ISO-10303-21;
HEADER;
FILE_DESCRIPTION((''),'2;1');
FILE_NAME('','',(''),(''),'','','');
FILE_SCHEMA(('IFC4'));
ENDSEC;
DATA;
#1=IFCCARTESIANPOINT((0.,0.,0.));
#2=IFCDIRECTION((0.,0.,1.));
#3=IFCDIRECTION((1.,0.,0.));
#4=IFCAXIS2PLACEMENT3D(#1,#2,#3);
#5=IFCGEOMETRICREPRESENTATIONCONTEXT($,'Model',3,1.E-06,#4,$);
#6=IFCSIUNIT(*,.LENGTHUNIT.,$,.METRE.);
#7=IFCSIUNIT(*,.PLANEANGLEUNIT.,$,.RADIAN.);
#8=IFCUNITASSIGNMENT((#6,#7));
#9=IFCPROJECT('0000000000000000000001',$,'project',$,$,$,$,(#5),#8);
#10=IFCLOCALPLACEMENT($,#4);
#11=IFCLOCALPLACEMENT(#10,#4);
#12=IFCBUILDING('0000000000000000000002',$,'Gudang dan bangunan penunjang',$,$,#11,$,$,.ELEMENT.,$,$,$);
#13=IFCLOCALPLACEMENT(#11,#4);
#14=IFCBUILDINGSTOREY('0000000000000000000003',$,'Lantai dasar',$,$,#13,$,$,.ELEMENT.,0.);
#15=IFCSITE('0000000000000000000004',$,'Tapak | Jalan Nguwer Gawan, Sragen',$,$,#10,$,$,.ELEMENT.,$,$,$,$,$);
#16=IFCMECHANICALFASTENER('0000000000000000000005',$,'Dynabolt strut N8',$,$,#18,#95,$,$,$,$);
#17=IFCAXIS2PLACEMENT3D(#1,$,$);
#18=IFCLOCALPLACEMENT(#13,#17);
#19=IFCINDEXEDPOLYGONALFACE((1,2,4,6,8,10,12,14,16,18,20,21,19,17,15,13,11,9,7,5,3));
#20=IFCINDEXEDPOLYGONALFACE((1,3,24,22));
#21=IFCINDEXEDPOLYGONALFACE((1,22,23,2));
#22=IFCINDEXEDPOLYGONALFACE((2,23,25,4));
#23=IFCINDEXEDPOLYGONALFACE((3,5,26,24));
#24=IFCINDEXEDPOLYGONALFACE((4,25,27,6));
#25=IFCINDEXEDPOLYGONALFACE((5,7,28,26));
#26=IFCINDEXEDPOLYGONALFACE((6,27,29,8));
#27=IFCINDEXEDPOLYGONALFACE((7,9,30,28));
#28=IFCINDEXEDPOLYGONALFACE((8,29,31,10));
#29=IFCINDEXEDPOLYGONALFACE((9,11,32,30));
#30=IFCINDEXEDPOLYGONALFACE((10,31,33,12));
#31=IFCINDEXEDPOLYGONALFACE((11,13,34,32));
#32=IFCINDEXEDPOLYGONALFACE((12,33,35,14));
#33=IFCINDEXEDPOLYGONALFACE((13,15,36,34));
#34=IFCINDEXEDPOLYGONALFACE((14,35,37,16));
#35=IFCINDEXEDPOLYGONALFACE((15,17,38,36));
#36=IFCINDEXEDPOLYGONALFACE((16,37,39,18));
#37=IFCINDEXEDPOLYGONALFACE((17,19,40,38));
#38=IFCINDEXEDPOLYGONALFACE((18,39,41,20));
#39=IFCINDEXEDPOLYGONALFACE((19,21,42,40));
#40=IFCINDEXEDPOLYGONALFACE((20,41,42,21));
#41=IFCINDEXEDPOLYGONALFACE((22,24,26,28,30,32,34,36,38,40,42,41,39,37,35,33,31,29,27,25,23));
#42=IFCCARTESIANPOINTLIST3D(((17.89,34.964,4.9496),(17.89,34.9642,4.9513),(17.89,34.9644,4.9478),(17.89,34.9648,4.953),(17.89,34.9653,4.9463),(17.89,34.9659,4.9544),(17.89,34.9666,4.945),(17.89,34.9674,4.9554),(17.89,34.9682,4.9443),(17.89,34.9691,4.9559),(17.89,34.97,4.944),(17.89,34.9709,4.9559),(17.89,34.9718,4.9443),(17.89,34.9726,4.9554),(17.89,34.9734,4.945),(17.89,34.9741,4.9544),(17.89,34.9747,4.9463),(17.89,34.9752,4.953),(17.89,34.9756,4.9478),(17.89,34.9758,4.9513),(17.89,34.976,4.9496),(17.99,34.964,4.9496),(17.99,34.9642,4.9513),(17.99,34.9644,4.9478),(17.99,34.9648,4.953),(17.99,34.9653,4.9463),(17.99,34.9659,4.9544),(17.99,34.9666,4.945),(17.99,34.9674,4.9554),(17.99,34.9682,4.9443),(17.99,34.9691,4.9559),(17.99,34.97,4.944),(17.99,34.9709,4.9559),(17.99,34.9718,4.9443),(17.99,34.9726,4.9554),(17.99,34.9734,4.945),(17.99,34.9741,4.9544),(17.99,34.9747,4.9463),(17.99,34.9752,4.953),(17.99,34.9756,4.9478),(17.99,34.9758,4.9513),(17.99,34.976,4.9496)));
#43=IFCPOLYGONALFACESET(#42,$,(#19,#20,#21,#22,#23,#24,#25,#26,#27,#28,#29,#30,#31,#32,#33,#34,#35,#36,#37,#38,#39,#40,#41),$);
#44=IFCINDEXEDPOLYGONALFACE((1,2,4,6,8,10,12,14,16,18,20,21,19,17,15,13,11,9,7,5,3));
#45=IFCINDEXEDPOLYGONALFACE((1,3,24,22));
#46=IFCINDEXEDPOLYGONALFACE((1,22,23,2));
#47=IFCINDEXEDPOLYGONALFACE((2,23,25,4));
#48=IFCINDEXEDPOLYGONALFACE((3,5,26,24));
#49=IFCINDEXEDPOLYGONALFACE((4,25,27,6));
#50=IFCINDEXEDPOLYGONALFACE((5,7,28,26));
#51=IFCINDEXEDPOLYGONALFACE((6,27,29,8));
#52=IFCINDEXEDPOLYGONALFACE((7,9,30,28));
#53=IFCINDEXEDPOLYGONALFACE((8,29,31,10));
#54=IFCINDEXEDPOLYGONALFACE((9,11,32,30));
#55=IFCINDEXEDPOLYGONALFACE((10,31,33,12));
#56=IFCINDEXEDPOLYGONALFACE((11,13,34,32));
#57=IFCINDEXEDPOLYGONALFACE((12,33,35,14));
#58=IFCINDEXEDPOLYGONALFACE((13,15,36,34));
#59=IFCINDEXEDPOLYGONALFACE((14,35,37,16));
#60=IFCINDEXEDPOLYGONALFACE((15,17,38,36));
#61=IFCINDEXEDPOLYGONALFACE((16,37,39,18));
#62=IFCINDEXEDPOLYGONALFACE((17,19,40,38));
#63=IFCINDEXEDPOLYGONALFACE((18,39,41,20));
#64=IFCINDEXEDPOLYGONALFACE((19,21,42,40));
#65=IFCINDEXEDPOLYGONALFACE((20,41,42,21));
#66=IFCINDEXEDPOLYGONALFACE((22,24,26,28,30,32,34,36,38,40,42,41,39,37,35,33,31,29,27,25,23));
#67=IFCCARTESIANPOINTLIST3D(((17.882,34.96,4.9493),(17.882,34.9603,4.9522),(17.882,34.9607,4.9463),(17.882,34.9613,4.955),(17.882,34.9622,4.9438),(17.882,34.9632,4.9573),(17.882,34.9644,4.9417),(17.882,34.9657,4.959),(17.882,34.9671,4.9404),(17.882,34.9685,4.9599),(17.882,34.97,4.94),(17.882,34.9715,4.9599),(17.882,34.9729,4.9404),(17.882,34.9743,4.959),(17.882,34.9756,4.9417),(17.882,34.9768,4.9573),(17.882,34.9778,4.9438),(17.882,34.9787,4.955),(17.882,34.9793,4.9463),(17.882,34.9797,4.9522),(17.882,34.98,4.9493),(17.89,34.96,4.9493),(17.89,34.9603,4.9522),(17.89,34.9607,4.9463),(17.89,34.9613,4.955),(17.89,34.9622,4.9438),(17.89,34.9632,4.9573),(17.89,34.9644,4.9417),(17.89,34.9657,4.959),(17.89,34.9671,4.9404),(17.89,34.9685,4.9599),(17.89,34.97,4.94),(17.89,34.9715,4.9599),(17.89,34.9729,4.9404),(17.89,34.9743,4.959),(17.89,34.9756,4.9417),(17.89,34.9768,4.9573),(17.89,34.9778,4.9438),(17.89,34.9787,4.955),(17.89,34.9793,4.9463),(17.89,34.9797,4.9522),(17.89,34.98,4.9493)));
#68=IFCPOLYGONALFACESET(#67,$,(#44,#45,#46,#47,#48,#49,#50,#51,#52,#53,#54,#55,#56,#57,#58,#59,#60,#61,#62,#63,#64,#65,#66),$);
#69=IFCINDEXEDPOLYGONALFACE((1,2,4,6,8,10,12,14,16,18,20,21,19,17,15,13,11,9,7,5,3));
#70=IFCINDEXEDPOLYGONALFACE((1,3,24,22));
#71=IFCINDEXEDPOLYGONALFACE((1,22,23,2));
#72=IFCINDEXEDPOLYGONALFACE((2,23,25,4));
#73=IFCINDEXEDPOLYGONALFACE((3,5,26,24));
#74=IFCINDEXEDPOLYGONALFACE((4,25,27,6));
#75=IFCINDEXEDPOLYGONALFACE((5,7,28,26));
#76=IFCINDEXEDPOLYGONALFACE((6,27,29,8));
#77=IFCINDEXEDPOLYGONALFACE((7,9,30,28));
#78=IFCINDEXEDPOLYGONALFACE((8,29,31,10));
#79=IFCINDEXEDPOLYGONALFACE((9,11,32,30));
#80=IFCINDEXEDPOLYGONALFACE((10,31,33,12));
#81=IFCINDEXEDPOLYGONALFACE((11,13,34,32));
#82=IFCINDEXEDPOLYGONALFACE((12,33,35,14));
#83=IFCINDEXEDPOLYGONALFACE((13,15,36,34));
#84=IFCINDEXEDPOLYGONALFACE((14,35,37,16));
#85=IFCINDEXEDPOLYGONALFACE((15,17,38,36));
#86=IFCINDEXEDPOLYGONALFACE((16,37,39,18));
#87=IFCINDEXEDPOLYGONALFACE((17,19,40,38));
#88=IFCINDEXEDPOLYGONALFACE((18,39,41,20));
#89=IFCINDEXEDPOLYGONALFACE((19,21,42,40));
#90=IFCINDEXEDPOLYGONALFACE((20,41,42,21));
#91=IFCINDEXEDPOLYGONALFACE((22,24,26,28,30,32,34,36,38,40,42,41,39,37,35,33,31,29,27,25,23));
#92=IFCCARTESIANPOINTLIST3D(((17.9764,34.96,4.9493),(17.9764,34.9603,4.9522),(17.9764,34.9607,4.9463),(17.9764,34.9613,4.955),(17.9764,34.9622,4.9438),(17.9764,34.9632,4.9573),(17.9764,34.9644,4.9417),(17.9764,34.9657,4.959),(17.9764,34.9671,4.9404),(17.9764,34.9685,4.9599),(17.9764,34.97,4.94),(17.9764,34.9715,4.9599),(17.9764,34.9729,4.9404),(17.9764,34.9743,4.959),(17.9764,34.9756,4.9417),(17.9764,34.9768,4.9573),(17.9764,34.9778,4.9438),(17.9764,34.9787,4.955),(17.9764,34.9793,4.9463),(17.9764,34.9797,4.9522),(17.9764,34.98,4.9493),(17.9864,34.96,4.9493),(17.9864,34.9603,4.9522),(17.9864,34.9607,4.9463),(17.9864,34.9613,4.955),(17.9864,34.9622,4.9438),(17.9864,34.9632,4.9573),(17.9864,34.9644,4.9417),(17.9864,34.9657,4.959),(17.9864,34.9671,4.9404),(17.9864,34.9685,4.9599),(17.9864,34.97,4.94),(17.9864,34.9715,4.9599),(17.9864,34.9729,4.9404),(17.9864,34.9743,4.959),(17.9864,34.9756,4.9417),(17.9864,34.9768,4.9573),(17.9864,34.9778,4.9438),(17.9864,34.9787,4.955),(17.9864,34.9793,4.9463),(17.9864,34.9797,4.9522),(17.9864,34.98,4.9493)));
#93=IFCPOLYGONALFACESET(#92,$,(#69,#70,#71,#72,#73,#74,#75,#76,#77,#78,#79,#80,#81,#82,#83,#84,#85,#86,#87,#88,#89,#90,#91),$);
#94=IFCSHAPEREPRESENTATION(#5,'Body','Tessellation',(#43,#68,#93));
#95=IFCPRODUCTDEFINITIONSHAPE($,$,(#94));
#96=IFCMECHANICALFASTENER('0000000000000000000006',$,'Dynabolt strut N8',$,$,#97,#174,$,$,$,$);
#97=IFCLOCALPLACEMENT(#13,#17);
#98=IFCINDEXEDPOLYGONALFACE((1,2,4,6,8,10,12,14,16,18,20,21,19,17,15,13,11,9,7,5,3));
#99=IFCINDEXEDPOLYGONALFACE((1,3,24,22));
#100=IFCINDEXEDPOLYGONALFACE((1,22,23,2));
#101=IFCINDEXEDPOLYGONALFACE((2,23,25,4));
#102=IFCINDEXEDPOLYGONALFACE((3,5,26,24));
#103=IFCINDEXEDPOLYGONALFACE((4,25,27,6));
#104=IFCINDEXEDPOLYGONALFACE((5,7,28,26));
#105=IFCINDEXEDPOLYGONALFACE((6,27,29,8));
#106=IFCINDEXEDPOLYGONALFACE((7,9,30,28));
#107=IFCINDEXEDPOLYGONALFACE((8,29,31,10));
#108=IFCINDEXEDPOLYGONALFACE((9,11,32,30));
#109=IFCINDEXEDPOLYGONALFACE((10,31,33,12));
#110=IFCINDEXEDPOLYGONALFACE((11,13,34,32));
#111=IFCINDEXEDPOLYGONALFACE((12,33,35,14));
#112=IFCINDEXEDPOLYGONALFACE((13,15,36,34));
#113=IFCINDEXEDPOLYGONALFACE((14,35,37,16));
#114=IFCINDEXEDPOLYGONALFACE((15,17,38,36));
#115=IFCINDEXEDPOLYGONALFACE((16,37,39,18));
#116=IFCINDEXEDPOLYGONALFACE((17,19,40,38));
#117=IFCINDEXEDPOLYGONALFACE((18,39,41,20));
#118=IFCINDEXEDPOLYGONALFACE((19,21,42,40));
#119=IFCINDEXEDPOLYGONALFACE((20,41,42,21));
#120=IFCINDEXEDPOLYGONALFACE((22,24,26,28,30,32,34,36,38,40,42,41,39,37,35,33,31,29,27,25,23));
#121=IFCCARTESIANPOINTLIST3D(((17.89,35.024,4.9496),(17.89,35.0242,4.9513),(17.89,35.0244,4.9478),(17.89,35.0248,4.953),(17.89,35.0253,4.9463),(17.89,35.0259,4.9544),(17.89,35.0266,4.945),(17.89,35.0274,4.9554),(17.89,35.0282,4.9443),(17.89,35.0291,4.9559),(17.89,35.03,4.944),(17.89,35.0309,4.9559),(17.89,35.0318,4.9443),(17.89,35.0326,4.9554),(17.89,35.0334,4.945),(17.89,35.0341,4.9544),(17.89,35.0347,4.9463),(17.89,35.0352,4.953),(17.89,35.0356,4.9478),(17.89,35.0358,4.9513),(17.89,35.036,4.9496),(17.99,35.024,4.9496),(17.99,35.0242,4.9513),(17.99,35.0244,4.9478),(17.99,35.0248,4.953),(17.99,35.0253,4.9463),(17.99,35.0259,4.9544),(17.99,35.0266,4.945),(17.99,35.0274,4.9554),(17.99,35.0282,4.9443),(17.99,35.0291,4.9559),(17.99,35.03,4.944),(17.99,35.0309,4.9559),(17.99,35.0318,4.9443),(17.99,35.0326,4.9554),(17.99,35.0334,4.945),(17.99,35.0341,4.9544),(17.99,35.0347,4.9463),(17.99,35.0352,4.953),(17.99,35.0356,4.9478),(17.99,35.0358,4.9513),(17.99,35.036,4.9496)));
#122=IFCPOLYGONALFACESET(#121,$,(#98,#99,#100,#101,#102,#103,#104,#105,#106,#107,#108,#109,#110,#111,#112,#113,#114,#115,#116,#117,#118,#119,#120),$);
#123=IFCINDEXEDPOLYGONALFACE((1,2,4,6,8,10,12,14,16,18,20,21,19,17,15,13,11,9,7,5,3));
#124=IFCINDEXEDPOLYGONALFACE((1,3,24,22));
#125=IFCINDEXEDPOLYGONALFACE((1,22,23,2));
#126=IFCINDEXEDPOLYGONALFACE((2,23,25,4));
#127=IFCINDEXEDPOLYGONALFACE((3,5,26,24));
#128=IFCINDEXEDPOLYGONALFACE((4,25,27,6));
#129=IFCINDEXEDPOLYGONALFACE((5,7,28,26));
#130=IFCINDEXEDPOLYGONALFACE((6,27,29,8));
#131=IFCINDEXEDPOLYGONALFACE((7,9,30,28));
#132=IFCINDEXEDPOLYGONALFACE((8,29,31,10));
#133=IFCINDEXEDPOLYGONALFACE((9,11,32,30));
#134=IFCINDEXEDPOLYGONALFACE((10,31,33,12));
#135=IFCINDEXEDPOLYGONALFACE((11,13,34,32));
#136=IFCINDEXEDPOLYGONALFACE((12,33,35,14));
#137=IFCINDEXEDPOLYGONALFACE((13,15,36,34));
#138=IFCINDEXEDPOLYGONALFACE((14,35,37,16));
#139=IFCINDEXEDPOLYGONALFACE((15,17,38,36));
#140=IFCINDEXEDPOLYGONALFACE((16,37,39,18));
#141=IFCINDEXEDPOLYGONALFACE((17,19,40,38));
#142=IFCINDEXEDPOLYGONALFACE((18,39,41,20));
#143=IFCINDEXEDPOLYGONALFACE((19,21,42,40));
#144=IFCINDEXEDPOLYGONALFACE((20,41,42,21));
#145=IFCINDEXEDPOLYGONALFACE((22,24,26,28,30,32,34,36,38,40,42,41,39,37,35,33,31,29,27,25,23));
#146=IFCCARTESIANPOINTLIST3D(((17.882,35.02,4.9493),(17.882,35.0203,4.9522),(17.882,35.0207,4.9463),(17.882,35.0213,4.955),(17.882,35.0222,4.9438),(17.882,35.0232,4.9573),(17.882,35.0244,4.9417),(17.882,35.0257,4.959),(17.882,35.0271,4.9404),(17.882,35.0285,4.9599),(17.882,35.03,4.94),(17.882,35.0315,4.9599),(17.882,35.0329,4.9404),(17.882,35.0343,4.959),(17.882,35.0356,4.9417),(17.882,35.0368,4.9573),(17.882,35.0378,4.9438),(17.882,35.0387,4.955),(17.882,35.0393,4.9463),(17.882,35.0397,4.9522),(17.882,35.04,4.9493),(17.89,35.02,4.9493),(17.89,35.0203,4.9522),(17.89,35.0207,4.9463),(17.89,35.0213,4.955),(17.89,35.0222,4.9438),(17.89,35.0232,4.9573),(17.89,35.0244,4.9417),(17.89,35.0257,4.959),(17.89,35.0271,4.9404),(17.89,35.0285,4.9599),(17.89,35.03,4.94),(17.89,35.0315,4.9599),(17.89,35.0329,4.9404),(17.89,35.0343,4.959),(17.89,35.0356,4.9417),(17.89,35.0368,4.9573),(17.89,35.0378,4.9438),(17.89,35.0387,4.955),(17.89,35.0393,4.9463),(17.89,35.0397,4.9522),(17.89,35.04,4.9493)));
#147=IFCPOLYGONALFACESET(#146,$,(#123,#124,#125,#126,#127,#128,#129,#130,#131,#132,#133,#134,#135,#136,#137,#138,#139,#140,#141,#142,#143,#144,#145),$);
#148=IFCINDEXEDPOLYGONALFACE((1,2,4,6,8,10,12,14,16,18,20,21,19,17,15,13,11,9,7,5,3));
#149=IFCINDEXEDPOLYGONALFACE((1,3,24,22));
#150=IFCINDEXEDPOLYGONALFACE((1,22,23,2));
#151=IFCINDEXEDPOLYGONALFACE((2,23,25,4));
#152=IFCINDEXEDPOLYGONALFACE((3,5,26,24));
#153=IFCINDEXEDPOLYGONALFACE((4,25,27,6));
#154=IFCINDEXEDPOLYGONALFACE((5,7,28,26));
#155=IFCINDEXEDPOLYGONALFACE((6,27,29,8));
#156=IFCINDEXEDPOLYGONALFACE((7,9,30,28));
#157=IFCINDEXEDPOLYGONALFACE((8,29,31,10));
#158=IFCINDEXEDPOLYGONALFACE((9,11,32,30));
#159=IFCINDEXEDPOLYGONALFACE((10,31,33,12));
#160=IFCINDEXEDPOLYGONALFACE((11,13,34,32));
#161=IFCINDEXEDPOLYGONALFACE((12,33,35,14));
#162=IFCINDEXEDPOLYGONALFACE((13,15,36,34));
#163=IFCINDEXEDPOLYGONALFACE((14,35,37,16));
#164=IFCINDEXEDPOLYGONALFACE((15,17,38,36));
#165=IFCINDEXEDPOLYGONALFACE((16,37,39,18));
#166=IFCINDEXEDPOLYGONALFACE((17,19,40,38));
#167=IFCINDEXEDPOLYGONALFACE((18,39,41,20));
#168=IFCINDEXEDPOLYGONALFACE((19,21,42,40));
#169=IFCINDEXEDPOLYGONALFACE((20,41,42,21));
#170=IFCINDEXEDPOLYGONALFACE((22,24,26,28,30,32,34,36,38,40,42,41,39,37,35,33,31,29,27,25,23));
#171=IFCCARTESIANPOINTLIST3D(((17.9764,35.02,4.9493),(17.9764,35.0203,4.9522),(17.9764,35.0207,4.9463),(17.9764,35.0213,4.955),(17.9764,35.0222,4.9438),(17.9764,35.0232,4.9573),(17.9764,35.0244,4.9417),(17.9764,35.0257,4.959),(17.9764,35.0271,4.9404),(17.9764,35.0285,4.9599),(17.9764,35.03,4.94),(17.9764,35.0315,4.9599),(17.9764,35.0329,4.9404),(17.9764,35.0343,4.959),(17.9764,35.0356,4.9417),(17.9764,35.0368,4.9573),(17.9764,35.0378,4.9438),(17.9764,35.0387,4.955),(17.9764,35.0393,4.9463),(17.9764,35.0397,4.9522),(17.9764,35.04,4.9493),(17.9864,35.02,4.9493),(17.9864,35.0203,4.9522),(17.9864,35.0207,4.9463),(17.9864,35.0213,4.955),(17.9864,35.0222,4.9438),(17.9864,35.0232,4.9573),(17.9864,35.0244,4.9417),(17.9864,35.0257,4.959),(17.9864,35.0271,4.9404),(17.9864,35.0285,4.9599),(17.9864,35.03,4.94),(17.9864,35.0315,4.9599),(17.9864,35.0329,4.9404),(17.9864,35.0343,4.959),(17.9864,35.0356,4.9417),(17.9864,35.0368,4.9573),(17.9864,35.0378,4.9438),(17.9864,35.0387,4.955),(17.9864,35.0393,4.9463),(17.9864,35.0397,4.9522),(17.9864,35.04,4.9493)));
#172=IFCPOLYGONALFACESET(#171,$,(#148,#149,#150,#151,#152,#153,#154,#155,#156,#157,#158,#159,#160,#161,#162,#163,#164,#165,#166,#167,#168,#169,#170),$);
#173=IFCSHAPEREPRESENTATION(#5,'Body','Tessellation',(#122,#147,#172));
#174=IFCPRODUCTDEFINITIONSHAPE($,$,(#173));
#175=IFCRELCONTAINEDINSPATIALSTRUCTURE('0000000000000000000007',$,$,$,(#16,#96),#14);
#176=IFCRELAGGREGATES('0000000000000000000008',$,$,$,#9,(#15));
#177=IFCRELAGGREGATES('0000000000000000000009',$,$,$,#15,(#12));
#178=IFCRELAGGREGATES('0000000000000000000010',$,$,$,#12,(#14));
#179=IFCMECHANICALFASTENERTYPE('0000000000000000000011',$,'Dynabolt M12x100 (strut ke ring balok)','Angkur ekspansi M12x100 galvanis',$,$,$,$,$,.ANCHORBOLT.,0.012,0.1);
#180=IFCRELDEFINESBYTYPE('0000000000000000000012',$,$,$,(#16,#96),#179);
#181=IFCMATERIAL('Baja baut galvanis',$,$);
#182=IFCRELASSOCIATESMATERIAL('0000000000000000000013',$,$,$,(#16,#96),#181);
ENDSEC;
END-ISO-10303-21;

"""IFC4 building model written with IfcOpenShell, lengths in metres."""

from ifc_helpers import new_model, si_unit, frame, origin_with_axes, place, context, project, spatial, circle, extrude, source, transform, mapped, material, type_object, type_shapes, element, save


model = new_model("IFC4")

# Units and contexts
model_context = context("Model", 3, precision=1e-06, world=origin_with_axes())
ifc_project = project(units=[si_unit("LENGTHUNIT", "METRE"), si_unit("PLANEANGLEUNIT", "RADIAN")], contexts=[model_context])

# Site, building, storey
site_placement = place(None, origin_with_axes())
site = spatial("IfcSite", under=ifc_project, at=site_placement, Name="Tapak | Jalan Nguwer Gawan, Sragen", CompositionType="ELEMENT")
building_placement = place(site_placement, origin_with_axes())
building = spatial("IfcBuilding", under=site, at=building_placement, Name="Gudang dan bangunan penunjang", CompositionType="ELEMENT")
storey_placement = place(building_placement, origin_with_axes())
storey = spatial("IfcBuildingStorey", under=building, at=storey_placement, Name="Lantai dasar", CompositionType="ELEMENT", Elevation=0.0)

# Mechanical fasteners
ifc_material = material(Name="Baja baut galvanis")
mechanical_fastener_type = type_object("IfcMechanicalFastenerType", Name="Dynabolt M12x100 (strut ke ring balok)", Description="Angkur ekspansi M12x100 galvanis", NominalDiameter=0.012, NominalLength=0.1, PredefinedType="ANCHORBOLT")
shared_shape = source(origin_with_axes(), model_context, "Body", "SweptSolid", [
    extrude(circle(Radius=0.006), origin_with_axes(), (0.0, 0.0, 1.0), 0.1),
    extrude(circle(Radius=0.01), frame((0.0, 0.0, -0.008), z_axis=(0.0, 0.0, 1.0), x_axis=(1.0, 0.0, 0.0)), (0.0, 0.0, 1.0), 0.008),
    extrude(circle(Radius=0.01), frame((0.0, 0.0, 0.0864), z_axis=(0.0, 0.0, 1.0), x_axis=(1.0, 0.0, 0.0)), (0.0, 0.0, 1.0), 0.01),
])
type_shapes(mechanical_fastener_type, [shared_shape])
placement = place(None, origin_with_axes())
element("IfcMechanicalFastener", 1, at=placement, inside=storey, type_object=mechanical_fastener_type, material=ifc_material, Name="Dynabolt strut N8", context=model_context, shape_type="MappedRepresentation", body=[
    mapped(shared_shape, transform((17.89, 34.97, 4.95), x_axis=(0.0, 0.0, -1.0), y_axis=(0.0, 1.0, 0.0), z_axis=(1.0, 0.0, 0.0), scale=1.0)),
])
element("IfcMechanicalFastener", 2, at=placement, inside=storey, type_object=mechanical_fastener_type, material=ifc_material, Name="Dynabolt strut N8", context=model_context, shape_type="MappedRepresentation", body=[
    mapped(shared_shape, transform((17.89, 35.03, 4.95), x_axis=(0.0, 0.0, -1.0), y_axis=(0.0, 1.0, 0.0), z_axis=(1.0, 0.0, 0.0), scale=1.0)),
])

save(model, "model.ifc")
